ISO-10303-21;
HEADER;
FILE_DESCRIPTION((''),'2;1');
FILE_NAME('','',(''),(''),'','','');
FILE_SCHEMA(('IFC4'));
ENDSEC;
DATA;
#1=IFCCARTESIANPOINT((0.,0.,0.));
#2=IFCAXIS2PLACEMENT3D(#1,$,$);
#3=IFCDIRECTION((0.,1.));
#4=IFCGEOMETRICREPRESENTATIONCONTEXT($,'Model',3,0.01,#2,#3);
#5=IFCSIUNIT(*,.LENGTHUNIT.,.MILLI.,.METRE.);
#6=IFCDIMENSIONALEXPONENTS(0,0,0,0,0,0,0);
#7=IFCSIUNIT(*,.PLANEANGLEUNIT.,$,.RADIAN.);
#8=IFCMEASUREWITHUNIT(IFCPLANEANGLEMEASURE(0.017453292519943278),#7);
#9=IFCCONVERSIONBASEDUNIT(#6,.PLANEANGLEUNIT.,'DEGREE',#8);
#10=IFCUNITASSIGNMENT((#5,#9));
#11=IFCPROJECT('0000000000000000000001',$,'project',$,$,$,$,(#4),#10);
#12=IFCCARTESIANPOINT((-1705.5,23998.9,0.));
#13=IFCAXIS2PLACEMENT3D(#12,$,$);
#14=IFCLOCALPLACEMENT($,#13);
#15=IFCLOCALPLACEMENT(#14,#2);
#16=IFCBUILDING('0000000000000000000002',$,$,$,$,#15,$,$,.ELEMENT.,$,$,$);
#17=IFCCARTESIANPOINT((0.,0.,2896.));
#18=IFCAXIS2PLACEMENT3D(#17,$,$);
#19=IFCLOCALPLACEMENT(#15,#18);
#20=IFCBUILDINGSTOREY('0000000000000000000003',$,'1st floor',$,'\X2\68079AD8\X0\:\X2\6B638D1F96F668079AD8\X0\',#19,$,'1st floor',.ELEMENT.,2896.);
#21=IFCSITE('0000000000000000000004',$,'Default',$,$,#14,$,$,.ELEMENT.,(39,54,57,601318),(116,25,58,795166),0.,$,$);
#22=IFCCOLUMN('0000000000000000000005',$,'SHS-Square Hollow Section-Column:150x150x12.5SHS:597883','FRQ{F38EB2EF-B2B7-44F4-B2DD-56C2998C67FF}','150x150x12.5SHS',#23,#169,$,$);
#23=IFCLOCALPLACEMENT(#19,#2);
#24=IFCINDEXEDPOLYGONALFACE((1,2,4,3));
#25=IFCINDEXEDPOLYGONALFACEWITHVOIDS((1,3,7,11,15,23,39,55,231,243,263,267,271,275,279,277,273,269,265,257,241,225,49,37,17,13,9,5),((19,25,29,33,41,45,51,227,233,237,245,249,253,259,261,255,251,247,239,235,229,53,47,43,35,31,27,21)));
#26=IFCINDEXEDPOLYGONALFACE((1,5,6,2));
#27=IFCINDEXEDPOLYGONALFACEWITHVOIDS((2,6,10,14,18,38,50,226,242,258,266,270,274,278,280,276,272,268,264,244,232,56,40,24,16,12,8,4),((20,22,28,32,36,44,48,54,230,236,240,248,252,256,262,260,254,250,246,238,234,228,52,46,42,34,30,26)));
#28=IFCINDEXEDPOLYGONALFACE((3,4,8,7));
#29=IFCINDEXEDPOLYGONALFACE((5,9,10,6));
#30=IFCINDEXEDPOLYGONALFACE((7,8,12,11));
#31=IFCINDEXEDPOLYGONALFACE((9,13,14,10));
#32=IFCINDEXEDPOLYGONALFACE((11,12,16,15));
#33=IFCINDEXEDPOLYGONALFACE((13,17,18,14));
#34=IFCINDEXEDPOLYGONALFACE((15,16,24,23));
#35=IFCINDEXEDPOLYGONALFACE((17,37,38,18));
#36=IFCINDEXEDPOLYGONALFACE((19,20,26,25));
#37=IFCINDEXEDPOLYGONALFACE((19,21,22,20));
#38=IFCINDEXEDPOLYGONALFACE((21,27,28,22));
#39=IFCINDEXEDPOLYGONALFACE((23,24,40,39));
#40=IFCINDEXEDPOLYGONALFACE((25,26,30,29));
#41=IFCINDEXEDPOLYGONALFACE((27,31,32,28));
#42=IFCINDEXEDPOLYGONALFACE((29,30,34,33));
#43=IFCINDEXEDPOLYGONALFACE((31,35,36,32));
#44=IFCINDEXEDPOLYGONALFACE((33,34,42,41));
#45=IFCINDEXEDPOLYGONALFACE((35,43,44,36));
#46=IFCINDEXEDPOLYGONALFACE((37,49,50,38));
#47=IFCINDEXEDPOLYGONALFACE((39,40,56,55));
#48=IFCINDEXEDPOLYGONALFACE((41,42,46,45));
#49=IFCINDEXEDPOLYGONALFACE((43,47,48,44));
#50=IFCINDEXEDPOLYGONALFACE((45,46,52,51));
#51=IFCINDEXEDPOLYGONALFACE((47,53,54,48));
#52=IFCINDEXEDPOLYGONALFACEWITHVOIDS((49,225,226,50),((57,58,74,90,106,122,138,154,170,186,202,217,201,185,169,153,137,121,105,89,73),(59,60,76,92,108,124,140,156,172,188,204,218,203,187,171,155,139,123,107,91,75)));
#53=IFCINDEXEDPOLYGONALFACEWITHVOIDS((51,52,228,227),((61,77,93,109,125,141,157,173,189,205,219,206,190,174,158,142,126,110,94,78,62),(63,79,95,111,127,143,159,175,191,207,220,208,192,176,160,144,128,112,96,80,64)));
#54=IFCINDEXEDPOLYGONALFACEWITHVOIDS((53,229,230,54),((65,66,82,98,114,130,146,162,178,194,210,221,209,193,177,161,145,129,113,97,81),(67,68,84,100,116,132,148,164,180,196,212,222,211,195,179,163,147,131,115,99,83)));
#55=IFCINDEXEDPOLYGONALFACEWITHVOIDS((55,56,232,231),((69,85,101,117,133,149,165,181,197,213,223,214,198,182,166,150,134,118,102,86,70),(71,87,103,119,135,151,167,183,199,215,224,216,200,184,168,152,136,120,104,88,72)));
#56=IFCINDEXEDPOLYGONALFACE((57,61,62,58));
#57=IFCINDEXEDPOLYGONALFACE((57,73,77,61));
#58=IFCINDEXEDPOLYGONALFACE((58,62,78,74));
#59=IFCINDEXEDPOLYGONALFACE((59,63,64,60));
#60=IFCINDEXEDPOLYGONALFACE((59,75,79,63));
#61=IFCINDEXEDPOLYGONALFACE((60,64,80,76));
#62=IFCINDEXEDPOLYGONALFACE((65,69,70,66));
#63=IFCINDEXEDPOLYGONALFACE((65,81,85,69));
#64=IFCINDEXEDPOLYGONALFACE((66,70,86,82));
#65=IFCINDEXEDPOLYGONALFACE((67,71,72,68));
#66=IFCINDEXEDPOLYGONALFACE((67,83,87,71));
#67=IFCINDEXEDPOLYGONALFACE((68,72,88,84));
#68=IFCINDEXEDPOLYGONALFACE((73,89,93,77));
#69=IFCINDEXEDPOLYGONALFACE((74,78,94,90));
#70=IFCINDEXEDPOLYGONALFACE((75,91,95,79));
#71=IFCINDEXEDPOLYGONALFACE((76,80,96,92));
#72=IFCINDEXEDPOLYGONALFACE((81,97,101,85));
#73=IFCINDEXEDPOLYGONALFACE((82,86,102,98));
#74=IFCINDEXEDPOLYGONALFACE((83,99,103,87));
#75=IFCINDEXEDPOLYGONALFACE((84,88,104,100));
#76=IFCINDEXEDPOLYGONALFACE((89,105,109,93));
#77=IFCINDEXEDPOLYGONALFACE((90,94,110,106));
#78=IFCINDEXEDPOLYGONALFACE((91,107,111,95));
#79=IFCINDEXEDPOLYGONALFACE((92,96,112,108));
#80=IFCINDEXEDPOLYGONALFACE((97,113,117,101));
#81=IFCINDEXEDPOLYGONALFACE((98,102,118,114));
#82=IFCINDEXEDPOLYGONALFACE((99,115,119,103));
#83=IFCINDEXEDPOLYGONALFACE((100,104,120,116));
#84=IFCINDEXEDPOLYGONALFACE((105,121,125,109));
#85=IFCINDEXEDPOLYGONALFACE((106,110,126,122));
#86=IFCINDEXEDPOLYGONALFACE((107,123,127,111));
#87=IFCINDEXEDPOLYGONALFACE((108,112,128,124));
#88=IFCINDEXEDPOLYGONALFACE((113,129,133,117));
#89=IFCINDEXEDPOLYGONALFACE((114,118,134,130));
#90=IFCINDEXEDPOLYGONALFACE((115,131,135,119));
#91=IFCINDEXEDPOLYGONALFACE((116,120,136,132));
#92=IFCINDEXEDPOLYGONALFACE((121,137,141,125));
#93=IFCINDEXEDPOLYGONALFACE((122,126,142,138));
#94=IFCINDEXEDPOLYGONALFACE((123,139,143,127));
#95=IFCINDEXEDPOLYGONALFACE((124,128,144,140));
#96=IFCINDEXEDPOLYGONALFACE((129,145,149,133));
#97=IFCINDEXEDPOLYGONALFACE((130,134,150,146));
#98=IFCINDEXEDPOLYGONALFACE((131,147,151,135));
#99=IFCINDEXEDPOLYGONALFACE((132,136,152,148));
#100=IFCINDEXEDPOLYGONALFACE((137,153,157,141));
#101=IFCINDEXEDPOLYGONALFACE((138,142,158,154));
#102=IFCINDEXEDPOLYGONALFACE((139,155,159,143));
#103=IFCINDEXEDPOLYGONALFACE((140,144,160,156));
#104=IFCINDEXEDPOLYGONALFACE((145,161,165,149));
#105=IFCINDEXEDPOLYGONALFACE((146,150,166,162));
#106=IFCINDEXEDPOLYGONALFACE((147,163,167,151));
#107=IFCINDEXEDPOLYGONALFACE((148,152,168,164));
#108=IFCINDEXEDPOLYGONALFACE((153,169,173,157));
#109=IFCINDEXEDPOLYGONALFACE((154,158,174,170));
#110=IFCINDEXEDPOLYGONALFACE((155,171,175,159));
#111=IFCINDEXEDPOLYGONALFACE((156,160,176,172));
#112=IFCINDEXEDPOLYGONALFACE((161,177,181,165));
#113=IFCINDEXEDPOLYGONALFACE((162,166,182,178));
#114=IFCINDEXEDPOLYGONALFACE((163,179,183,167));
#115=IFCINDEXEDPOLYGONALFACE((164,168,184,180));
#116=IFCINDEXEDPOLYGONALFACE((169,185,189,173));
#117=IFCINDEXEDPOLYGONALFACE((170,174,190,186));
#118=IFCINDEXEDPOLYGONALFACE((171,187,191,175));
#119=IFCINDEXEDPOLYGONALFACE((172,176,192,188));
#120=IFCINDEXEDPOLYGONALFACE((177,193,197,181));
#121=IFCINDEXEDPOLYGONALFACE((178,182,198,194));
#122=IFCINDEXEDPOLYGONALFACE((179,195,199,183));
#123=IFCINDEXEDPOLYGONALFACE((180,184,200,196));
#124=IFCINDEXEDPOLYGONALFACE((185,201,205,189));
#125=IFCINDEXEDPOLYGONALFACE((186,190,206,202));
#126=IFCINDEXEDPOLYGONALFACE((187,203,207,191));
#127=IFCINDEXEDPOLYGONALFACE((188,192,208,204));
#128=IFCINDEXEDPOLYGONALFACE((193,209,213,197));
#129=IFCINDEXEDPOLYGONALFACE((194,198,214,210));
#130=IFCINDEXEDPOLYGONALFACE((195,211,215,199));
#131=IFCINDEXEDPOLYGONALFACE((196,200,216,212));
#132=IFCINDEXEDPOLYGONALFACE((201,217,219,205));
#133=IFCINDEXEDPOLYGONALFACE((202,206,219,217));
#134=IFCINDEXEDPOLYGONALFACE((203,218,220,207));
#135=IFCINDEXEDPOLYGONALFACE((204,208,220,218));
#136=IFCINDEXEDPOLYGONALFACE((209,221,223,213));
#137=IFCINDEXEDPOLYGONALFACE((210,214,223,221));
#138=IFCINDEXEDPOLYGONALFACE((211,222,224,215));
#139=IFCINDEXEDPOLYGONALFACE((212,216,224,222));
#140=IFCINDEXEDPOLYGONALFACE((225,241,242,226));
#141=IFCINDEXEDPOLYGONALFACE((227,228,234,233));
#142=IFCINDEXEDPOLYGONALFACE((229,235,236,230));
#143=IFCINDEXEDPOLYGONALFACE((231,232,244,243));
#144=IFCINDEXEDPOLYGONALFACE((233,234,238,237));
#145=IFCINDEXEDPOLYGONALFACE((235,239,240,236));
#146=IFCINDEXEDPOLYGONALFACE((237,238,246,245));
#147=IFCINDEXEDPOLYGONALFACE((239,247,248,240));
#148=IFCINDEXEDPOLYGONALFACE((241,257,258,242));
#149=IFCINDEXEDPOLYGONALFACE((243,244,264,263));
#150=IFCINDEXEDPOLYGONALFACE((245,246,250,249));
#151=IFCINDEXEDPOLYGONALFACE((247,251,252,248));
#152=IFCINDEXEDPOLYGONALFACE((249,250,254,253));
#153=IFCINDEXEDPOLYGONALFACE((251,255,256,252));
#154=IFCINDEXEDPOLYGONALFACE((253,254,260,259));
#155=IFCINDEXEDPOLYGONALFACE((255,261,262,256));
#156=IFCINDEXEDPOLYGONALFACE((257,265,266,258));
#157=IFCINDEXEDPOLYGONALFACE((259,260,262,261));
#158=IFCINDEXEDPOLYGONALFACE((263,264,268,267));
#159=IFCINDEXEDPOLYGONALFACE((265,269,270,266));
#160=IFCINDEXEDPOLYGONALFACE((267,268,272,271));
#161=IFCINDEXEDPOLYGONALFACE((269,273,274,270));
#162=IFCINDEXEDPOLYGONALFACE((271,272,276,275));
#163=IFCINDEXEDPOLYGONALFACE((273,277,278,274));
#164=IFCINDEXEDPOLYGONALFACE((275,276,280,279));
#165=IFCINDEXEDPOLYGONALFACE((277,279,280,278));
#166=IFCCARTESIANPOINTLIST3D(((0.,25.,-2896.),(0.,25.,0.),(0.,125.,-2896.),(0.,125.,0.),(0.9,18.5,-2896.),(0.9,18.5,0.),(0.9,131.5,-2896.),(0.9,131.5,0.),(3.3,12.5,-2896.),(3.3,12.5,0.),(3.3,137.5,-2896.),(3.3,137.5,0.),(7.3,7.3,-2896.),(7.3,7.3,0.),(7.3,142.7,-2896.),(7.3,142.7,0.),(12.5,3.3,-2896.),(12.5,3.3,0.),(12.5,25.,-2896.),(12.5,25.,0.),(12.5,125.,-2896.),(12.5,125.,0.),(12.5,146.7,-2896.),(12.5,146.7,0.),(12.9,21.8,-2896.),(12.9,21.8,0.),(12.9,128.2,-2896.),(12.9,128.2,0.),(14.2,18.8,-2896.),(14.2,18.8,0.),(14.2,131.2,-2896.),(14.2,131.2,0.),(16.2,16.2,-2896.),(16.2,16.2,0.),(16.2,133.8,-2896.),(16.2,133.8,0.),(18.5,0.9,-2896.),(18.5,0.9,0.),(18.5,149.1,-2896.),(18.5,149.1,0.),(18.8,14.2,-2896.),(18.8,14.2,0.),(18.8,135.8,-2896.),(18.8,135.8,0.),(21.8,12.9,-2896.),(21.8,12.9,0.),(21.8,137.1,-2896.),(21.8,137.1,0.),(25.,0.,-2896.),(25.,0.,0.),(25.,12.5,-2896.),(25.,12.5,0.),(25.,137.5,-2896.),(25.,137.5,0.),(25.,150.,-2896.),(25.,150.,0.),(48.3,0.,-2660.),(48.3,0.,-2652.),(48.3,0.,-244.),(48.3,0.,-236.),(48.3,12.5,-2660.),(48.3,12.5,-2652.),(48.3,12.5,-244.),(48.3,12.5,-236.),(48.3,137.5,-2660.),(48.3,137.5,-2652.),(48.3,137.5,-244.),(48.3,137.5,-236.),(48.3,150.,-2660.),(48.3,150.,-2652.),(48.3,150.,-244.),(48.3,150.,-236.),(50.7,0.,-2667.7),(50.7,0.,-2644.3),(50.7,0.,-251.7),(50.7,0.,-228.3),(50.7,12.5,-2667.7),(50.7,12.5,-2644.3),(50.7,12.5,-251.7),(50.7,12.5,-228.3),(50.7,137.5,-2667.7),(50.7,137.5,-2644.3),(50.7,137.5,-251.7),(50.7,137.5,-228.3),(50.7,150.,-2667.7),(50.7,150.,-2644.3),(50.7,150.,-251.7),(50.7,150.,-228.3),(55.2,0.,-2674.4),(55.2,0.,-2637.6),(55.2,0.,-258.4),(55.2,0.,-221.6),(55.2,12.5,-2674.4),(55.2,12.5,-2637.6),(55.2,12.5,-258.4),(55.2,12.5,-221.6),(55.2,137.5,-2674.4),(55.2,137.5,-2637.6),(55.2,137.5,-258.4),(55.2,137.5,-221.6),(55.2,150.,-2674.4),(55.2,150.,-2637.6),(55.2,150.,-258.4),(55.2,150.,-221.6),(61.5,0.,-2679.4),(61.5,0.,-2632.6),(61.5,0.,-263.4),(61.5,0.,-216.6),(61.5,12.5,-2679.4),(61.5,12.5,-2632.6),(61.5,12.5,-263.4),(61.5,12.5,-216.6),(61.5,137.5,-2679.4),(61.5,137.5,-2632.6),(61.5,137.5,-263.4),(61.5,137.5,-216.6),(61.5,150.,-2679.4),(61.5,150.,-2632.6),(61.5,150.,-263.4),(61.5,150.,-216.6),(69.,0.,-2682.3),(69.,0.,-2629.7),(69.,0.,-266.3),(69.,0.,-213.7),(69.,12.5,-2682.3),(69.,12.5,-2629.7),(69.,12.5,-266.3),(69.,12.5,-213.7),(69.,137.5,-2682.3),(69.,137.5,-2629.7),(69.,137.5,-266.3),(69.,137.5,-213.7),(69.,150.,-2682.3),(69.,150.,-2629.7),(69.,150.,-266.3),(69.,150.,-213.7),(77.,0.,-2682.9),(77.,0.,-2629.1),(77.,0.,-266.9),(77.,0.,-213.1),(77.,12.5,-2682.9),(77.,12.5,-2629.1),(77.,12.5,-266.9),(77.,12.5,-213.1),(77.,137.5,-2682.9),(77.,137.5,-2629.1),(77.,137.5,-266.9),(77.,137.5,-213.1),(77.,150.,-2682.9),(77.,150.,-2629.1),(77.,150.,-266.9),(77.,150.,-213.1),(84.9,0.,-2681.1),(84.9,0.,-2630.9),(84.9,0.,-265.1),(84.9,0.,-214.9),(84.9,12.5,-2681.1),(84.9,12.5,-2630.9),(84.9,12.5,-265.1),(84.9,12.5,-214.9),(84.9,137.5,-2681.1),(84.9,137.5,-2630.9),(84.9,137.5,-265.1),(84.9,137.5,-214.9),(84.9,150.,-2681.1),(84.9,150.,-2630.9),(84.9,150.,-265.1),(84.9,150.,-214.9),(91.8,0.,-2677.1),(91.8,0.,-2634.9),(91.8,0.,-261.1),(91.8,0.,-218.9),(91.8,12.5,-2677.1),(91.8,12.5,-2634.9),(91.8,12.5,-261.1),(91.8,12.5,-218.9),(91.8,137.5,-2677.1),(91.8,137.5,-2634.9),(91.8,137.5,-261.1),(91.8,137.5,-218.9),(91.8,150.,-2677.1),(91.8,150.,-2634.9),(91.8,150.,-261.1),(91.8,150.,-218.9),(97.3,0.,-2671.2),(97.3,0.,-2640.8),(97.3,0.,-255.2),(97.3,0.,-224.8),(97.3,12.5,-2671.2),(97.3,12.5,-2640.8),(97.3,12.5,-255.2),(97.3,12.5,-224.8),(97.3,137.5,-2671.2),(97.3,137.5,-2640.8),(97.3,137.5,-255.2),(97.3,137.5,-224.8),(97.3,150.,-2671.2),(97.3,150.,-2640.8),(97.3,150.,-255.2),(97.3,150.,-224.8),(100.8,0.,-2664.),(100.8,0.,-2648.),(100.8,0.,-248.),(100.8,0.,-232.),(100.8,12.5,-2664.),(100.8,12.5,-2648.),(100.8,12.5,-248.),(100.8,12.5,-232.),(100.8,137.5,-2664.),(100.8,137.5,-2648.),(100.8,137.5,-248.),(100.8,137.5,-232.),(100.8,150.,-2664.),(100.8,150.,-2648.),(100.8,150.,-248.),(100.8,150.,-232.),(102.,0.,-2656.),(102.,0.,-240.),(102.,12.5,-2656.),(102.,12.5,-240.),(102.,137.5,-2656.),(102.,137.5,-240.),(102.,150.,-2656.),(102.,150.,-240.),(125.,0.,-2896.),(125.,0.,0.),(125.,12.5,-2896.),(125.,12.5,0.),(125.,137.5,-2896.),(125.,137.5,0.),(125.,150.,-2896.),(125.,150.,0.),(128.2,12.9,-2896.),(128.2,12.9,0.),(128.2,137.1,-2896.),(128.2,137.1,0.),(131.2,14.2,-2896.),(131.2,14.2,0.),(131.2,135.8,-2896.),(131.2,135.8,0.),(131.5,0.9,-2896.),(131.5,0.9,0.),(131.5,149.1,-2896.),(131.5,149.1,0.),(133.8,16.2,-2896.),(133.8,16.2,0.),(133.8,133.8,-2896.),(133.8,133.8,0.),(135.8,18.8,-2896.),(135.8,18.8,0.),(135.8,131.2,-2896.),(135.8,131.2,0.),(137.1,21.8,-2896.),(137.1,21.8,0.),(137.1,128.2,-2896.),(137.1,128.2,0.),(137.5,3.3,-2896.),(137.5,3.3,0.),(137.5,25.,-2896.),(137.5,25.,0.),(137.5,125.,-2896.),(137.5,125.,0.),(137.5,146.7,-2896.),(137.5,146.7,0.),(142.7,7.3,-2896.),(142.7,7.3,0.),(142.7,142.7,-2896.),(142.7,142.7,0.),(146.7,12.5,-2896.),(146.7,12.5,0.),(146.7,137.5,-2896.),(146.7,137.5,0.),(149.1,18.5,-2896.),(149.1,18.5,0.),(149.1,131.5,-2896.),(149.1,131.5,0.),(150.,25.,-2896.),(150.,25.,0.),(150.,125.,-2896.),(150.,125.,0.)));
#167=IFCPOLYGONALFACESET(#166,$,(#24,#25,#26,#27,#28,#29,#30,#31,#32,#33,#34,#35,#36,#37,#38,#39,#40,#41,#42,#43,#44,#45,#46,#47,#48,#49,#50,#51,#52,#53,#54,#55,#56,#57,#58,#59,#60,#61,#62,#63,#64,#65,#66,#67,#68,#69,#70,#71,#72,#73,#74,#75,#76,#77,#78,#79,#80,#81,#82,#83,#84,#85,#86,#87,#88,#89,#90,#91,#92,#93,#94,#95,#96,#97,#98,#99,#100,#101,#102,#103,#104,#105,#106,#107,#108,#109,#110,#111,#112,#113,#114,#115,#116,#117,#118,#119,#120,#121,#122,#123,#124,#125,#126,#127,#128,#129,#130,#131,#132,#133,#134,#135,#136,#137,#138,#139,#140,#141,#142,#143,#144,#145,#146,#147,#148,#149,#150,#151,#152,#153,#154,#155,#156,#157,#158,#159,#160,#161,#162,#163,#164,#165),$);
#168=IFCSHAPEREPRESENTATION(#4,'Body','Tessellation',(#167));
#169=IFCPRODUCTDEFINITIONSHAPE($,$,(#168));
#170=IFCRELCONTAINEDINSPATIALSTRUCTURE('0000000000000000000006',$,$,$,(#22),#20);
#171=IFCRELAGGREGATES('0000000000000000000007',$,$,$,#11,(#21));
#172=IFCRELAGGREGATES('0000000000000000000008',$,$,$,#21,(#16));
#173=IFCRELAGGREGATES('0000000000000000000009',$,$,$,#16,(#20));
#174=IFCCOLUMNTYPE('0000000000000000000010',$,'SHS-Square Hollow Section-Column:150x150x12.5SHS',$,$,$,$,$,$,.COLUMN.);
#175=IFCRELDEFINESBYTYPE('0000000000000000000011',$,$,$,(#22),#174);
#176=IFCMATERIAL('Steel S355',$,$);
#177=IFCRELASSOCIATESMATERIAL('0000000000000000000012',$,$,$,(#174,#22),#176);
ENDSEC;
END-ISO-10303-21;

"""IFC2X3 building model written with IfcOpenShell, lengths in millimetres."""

from ifc_helpers import new_model, entity, si_unit, converted_unit, direction, frame, frame_2d, origin, origin_2d, place, context, project, spatial, circle_curve, hollow_rectangle, outline, extrude, material, type_object, element, save


model = new_model("IFC2X3")

# Units and contexts
model_context = context("Model", 3, precision=0.01, world=origin(), true_north=direction((0.0, 1.0)))
ifc_project = project(units=[si_unit("LENGTHUNIT", "METRE", prefix="MILLI"), converted_unit("PLANEANGLEUNIT", "DEGREE", entity("IfcPlaneAngleMeasure", 0.017453292519943278), si_unit("PLANEANGLEUNIT", "RADIAN"), dimensions=[0, 0, 0, 0, 0, 0, 0])], contexts=[model_context])

# Site, building, storey
site_placement = place(None, frame((-1705.5, 23998.9, 0.0)))
site = spatial("IfcSite", under=ifc_project, at=site_placement, Name="Default", CompositionType="ELEMENT", RefLatitude=(39, 54, 57, 601318), RefLongitude=(116, 25, 58, 795166), RefElevation=0.0)
building_placement = place(site_placement, origin())
building = spatial("IfcBuilding", under=site, at=building_placement, CompositionType="ELEMENT")
storey_placement = place(building_placement, frame((0.0, 0.0, 2896.0)))
storey = spatial("IfcBuildingStorey", under=building, at=storey_placement, Name="1st floor", ObjectType="标高:正负零标高", LongName="1st floor", CompositionType="ELEMENT", Elevation=2896.0)

# Column, openings
ifc_material_1 = material(Name="Steel S355")
column_type_1 = type_object("IfcColumnType", Name="SHS-Square Hollow Section-Column:150x150x12.5SHS", PredefinedType="COLUMN", material=ifc_material_1)
column_1_placement = place(storey_placement, frame((75.0, 75.0, 0.0), z_axis=(0.0, 0.0, 1.0), x_axis=(0.0, -1.0, 0.0)))
column_1 = element("IfcColumn", 1, at=column_1_placement, inside=storey, type_object=column_type_1, material=ifc_material_1, Name="SHS-Square Hollow Section-Column:150x150x12.5SHS:597883", Description="FRQ{F38EB2EF-B2B7-44F4-B2DD-56C2998C67FF}", ObjectType="150x150x12.5SHS", context=model_context, shape_type="SweptSolid", body=[
    extrude(hollow_rectangle(XDim=150.0, YDim=150.0, WallThickness=12.5, InnerFilletRadius=12.5, OuterFilletRadius=25.0, at=origin_2d()), origin(), (0.0, 0.0, -1.0), 2896.0),
])
opening_1_placement = place(column_1_placement, frame((-175.1, 0.0, -2896.0), z_axis=(1.0, 0.0, 0.0), x_axis=(0.0, 1.0, 0.0)))
element("IfcOpeningElement", 2, at=opening_1_placement, cuts=column_1, ObjectType="Opening", context=model_context, shape_type="SweptSolid", body=[
    extrude(outline(circle_curve(frame_2d((0.0, 240.0), x_axis=(1.0, 0.0)), 27.0)), origin(), (0.0, 0.0, 1.0), 350.2),
])
opening_2_placement = place(column_1_placement, frame((-175.1, 0.0, 0.0), z_axis=(1.0, 0.0, 0.0), x_axis=(0.0, 1.0, 0.0)))
element("IfcOpeningElement", 3, at=opening_2_placement, cuts=column_1, ObjectType="Opening", context=model_context, shape_type="SweptSolid", body=[
    extrude(outline(circle_curve(frame_2d((0.0, -240.0), x_axis=(1.0, 0.0)), 27.0)), origin(), (0.0, 0.0, 1.0), 350.2),
])

save(model, "model.ifc")
